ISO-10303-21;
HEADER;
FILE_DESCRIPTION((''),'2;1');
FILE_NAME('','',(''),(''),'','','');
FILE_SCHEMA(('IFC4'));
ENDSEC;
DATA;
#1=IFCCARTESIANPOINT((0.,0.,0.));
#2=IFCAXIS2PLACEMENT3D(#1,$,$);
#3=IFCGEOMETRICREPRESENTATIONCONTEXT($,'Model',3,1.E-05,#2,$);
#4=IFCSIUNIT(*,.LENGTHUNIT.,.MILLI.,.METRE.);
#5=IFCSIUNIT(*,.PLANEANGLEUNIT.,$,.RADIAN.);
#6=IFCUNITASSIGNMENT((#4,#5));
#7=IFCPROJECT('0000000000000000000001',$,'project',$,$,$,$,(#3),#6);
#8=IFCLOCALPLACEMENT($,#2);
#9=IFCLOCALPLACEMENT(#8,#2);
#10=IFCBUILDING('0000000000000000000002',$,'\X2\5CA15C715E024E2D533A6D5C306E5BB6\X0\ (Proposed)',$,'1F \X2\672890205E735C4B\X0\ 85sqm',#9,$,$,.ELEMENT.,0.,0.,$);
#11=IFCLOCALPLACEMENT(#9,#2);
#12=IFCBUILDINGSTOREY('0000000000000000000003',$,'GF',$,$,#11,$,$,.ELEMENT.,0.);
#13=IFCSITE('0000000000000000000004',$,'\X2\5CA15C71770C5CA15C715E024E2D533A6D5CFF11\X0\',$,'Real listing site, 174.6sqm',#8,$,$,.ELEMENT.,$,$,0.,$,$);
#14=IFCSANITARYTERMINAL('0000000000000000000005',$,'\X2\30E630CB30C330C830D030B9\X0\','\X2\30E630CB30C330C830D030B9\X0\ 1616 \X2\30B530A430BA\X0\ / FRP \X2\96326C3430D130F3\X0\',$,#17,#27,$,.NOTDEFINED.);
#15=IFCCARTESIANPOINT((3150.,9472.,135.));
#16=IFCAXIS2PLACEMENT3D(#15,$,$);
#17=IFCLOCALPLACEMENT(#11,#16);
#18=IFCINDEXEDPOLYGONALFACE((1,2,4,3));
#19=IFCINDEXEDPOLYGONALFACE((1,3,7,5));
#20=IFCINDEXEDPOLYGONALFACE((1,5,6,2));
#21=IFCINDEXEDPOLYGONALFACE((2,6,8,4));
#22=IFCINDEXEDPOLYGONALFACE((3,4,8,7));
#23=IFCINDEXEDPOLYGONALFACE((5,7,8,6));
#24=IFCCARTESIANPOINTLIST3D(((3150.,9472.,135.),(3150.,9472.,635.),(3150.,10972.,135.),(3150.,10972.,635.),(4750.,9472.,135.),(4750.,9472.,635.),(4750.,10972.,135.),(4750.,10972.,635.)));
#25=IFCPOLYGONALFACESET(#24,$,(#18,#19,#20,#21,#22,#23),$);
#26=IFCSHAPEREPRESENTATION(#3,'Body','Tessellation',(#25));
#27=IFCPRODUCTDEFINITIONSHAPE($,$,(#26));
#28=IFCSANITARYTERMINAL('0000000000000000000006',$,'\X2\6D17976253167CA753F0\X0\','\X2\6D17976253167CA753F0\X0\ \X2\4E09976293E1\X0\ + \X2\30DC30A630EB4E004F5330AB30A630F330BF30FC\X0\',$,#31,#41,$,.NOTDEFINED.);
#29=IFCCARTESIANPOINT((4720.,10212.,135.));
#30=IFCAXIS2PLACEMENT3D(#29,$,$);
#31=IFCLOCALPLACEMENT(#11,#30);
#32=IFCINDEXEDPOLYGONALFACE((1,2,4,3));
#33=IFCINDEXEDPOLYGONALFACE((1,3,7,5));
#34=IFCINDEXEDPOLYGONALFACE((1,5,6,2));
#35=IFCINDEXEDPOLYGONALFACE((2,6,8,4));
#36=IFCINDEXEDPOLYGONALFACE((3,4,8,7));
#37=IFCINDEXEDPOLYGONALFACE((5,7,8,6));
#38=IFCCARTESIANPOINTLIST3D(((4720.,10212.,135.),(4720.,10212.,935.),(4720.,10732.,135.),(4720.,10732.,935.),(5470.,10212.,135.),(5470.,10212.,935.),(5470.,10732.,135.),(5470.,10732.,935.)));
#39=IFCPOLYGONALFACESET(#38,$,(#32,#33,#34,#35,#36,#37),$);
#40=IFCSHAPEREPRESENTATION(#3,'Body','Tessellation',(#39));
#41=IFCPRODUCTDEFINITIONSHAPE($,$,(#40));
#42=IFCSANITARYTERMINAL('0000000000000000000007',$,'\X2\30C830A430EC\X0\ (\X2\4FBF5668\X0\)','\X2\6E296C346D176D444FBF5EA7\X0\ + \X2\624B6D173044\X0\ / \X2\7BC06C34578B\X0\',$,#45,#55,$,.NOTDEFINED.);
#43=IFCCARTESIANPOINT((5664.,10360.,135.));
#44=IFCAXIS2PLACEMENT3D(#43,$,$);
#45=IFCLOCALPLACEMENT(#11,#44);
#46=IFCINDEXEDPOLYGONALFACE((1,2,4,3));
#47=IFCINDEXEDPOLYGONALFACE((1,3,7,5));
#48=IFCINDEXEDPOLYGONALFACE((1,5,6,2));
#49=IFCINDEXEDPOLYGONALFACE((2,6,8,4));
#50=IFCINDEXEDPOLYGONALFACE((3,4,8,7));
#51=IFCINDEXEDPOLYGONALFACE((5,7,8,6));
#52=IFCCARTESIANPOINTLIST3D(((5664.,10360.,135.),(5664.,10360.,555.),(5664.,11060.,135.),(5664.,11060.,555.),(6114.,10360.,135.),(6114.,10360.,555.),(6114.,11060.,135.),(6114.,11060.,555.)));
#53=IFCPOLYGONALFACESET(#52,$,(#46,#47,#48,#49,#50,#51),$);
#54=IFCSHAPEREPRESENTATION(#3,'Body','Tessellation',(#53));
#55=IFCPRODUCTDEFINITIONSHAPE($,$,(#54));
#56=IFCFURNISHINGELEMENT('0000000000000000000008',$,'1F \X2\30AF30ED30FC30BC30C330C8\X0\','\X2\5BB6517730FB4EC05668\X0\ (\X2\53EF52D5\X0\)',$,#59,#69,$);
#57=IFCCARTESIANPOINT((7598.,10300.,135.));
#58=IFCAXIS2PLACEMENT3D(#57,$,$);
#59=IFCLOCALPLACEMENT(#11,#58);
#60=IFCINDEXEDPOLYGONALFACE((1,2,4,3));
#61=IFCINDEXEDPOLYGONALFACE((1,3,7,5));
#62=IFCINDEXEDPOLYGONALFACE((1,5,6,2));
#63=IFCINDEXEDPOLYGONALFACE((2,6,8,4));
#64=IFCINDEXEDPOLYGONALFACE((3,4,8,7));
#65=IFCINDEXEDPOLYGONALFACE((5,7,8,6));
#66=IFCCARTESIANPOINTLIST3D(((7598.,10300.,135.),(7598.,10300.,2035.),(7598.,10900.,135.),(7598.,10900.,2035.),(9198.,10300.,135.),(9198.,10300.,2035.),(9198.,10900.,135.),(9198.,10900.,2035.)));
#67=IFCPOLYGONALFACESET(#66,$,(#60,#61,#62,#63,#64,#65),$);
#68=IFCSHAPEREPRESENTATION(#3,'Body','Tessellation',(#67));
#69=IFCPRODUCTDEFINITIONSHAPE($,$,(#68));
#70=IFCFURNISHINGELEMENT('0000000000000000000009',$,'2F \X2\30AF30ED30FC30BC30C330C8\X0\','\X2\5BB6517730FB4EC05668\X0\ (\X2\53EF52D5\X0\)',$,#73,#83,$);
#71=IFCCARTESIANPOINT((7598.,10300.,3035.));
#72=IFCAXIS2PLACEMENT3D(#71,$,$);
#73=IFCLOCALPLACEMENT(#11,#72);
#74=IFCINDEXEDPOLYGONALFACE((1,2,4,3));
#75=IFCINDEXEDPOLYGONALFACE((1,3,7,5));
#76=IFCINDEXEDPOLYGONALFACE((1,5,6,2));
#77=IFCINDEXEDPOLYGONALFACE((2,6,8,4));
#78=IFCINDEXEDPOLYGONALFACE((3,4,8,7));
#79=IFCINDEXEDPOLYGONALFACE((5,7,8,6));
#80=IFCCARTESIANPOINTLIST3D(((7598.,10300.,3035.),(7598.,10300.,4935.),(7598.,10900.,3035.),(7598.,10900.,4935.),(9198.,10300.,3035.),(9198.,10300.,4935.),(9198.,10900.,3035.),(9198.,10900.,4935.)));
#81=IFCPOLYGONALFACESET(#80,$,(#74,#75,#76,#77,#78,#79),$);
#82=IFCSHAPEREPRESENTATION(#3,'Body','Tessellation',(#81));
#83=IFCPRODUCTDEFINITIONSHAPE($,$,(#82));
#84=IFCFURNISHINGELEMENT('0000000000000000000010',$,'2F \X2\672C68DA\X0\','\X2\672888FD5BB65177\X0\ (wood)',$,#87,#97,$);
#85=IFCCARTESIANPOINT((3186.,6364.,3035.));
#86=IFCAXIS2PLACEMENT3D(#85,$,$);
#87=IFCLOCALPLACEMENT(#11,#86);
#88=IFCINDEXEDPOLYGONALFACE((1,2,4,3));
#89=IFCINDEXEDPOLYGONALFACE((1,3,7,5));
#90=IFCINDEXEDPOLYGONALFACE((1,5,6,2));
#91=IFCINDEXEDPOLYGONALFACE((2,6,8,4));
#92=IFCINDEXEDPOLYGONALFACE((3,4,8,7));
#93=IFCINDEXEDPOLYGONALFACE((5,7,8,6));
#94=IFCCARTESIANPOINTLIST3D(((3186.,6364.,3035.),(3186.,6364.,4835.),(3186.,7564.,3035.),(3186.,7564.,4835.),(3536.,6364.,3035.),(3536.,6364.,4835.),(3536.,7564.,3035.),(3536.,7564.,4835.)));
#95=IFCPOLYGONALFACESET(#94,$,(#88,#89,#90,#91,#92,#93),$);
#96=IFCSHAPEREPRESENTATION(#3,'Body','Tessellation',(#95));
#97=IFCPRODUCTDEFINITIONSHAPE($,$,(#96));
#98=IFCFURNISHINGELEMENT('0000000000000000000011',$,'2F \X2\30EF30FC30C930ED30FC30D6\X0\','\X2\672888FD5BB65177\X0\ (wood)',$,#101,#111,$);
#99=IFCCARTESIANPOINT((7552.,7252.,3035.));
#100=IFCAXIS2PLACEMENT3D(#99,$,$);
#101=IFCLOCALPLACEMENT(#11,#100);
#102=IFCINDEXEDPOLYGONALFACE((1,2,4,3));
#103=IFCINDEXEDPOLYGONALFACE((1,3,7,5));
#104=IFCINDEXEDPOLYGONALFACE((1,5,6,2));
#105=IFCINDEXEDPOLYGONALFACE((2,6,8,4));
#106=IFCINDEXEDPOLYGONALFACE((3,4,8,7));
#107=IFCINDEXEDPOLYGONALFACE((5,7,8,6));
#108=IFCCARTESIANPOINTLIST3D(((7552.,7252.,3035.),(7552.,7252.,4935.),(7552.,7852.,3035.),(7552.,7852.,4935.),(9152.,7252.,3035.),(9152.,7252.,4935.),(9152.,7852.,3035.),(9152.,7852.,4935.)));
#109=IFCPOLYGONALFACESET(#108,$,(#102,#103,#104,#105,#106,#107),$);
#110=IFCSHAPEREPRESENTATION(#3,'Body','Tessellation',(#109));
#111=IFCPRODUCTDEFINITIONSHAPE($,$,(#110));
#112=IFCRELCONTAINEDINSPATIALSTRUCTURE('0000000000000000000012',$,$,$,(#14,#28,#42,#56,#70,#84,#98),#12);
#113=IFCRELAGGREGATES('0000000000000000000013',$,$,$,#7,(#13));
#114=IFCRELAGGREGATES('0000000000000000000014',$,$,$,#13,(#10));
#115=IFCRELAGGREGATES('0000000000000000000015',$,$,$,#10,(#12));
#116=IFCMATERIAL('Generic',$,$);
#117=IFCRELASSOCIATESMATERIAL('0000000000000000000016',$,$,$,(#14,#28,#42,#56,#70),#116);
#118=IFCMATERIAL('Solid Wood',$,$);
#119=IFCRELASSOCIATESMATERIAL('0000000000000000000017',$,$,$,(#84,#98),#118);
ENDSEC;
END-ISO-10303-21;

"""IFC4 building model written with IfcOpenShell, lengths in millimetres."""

from ifc_helpers import new_model, si_unit, frame, frame_2d, origin, place, context, project, spatial, rectangle, extrude, material, element, save


model = new_model("IFC4")

# Units and contexts
model_context = context("Model", 3, precision=1e-05, world=origin())
ifc_project = project(units=[si_unit("LENGTHUNIT", "METRE", prefix="MILLI"), si_unit("PLANEANGLEUNIT", "RADIAN")], contexts=[model_context])

# Site, building, storey
site_placement = place(None, origin())
site = spatial("IfcSite", under=ifc_project, at=site_placement, Name="岡山県岡山市中区浜１", ObjectType="Real listing site, 174.6sqm", CompositionType="ELEMENT", RefElevation=0.0)
building_placement = place(site_placement, origin())
building = spatial("IfcBuilding", under=site, at=building_placement, Name="岡山市中区浜の家 (Proposed)", ObjectType="1F 木造平屋 85sqm", CompositionType="ELEMENT", ElevationOfRefHeight=0.0, ElevationOfTerrain=0.0)
storey_placement = place(building_placement, origin())
storey = spatial("IfcBuildingStorey", under=building, at=storey_placement, Name="GF", CompositionType="ELEMENT", Elevation=0.0)

# Shared definitions
ifc_material_1 = material(Name="Solid Wood")

# Shared definitions
ifc_material_2 = material(Name="Generic")

# Sanitary terminals
sanitary_terminal_1_placement = place(storey_placement, frame((3150.0, 9472.0, 135.0)))
element("IfcSanitaryTerminal", 1, at=sanitary_terminal_1_placement, inside=storey, material=ifc_material_2, Name="ユニットバス", Description="ユニットバス 1616 サイズ / FRP 防水パン", PredefinedType="NOTDEFINED", context=model_context, shape_type="SweptSolid", body=[
    extrude(rectangle(XDim=1600.0, YDim=1500.0, at=frame_2d((800.0, 750.0))), frame((3150.0, 9472.0, 135.0)), (0.0, 0.0, 1.0), 500.0),
])
sanitary_terminal_2_placement = place(storey_placement, frame((4720.0, 10212.0, 135.0)))
element("IfcSanitaryTerminal", 2, at=sanitary_terminal_2_placement, inside=storey, material=ifc_material_2, Name="洗面化粧台", Description="洗面化粧台 三面鏡 + ボウル一体カウンター", PredefinedType="NOTDEFINED", context=model_context, shape_type="SweptSolid", body=[
    extrude(rectangle(XDim=750.0, YDim=520.0, at=frame_2d((375.0, 260.0))), frame((4720.0, 10212.0, 135.0)), (0.0, 0.0, 1.0), 800.0),
])
sanitary_terminal_3_placement = place(storey_placement, frame((5664.0, 10360.0, 135.0)))
element("IfcSanitaryTerminal", 3, at=sanitary_terminal_3_placement, inside=storey, material=ifc_material_2, Name="トイレ (便器)", Description="温水洗浄便座 + 手洗い / 節水型", PredefinedType="NOTDEFINED", context=model_context, shape_type="SweptSolid", body=[
    extrude(rectangle(XDim=450.0, YDim=700.0, at=frame_2d((225.0, 350.0))), frame((5664.0, 10360.0, 135.0)), (0.0, 0.0, 1.0), 420.0),
])

# Furnishing elements
furnishing_1_placement = place(storey_placement, frame((7598.0, 10300.0, 135.0)))
element("IfcFurnishingElement", 4, at=furnishing_1_placement, inside=storey, material=ifc_material_2, Name="1F クローゼット", Description="家具・什器 (可動)", context=model_context, shape_type="SweptSolid", body=[
    extrude(rectangle(XDim=1600.0, YDim=600.0, at=frame_2d((800.0, 300.0))), frame((7598.0, 10300.0, 135.0)), (0.0, 0.0, 1.0), 1900.0),
])
furnishing_2_placement = place(storey_placement, frame((7598.0, 10300.0, 3035.0)))
element("IfcFurnishingElement", 5, at=furnishing_2_placement, inside=storey, material=ifc_material_2, Name="2F クローゼット", Description="家具・什器 (可動)", context=model_context, shape_type="SweptSolid", body=[
    extrude(rectangle(XDim=1600.0, YDim=600.0, at=frame_2d((800.0, 300.0))), frame((7598.0, 10300.0, 3035.0)), (0.0, 0.0, 1.0), 1900.0),
])
furnishing_3_placement = place(storey_placement, frame((3186.0, 6364.0, 3035.0)))
element("IfcFurnishingElement", 6, at=furnishing_3_placement, inside=storey, material=ifc_material_1, Name="2F 本棚", Description="木製家具 (wood)", context=model_context, shape_type="SweptSolid", body=[
    extrude(rectangle(XDim=350.0, YDim=1200.0, at=frame_2d((175.0, 600.0))), frame((3186.0, 6364.0, 3035.0)), (0.0, 0.0, 1.0), 1800.0),
])
furnishing_4_placement = place(storey_placement, frame((7552.0, 7252.0, 3035.0)))
element("IfcFurnishingElement", 7, at=furnishing_4_placement, inside=storey, material=ifc_material_1, Name="2F ワードローブ", Description="木製家具 (wood)", context=model_context, shape_type="SweptSolid", body=[
    extrude(rectangle(XDim=1600.0, YDim=600.0, at=frame_2d((800.0, 300.0))), frame((7552.0, 7252.0, 3035.0)), (0.0, 0.0, 1.0), 1900.0),
])

save(model, "model.ifc")
